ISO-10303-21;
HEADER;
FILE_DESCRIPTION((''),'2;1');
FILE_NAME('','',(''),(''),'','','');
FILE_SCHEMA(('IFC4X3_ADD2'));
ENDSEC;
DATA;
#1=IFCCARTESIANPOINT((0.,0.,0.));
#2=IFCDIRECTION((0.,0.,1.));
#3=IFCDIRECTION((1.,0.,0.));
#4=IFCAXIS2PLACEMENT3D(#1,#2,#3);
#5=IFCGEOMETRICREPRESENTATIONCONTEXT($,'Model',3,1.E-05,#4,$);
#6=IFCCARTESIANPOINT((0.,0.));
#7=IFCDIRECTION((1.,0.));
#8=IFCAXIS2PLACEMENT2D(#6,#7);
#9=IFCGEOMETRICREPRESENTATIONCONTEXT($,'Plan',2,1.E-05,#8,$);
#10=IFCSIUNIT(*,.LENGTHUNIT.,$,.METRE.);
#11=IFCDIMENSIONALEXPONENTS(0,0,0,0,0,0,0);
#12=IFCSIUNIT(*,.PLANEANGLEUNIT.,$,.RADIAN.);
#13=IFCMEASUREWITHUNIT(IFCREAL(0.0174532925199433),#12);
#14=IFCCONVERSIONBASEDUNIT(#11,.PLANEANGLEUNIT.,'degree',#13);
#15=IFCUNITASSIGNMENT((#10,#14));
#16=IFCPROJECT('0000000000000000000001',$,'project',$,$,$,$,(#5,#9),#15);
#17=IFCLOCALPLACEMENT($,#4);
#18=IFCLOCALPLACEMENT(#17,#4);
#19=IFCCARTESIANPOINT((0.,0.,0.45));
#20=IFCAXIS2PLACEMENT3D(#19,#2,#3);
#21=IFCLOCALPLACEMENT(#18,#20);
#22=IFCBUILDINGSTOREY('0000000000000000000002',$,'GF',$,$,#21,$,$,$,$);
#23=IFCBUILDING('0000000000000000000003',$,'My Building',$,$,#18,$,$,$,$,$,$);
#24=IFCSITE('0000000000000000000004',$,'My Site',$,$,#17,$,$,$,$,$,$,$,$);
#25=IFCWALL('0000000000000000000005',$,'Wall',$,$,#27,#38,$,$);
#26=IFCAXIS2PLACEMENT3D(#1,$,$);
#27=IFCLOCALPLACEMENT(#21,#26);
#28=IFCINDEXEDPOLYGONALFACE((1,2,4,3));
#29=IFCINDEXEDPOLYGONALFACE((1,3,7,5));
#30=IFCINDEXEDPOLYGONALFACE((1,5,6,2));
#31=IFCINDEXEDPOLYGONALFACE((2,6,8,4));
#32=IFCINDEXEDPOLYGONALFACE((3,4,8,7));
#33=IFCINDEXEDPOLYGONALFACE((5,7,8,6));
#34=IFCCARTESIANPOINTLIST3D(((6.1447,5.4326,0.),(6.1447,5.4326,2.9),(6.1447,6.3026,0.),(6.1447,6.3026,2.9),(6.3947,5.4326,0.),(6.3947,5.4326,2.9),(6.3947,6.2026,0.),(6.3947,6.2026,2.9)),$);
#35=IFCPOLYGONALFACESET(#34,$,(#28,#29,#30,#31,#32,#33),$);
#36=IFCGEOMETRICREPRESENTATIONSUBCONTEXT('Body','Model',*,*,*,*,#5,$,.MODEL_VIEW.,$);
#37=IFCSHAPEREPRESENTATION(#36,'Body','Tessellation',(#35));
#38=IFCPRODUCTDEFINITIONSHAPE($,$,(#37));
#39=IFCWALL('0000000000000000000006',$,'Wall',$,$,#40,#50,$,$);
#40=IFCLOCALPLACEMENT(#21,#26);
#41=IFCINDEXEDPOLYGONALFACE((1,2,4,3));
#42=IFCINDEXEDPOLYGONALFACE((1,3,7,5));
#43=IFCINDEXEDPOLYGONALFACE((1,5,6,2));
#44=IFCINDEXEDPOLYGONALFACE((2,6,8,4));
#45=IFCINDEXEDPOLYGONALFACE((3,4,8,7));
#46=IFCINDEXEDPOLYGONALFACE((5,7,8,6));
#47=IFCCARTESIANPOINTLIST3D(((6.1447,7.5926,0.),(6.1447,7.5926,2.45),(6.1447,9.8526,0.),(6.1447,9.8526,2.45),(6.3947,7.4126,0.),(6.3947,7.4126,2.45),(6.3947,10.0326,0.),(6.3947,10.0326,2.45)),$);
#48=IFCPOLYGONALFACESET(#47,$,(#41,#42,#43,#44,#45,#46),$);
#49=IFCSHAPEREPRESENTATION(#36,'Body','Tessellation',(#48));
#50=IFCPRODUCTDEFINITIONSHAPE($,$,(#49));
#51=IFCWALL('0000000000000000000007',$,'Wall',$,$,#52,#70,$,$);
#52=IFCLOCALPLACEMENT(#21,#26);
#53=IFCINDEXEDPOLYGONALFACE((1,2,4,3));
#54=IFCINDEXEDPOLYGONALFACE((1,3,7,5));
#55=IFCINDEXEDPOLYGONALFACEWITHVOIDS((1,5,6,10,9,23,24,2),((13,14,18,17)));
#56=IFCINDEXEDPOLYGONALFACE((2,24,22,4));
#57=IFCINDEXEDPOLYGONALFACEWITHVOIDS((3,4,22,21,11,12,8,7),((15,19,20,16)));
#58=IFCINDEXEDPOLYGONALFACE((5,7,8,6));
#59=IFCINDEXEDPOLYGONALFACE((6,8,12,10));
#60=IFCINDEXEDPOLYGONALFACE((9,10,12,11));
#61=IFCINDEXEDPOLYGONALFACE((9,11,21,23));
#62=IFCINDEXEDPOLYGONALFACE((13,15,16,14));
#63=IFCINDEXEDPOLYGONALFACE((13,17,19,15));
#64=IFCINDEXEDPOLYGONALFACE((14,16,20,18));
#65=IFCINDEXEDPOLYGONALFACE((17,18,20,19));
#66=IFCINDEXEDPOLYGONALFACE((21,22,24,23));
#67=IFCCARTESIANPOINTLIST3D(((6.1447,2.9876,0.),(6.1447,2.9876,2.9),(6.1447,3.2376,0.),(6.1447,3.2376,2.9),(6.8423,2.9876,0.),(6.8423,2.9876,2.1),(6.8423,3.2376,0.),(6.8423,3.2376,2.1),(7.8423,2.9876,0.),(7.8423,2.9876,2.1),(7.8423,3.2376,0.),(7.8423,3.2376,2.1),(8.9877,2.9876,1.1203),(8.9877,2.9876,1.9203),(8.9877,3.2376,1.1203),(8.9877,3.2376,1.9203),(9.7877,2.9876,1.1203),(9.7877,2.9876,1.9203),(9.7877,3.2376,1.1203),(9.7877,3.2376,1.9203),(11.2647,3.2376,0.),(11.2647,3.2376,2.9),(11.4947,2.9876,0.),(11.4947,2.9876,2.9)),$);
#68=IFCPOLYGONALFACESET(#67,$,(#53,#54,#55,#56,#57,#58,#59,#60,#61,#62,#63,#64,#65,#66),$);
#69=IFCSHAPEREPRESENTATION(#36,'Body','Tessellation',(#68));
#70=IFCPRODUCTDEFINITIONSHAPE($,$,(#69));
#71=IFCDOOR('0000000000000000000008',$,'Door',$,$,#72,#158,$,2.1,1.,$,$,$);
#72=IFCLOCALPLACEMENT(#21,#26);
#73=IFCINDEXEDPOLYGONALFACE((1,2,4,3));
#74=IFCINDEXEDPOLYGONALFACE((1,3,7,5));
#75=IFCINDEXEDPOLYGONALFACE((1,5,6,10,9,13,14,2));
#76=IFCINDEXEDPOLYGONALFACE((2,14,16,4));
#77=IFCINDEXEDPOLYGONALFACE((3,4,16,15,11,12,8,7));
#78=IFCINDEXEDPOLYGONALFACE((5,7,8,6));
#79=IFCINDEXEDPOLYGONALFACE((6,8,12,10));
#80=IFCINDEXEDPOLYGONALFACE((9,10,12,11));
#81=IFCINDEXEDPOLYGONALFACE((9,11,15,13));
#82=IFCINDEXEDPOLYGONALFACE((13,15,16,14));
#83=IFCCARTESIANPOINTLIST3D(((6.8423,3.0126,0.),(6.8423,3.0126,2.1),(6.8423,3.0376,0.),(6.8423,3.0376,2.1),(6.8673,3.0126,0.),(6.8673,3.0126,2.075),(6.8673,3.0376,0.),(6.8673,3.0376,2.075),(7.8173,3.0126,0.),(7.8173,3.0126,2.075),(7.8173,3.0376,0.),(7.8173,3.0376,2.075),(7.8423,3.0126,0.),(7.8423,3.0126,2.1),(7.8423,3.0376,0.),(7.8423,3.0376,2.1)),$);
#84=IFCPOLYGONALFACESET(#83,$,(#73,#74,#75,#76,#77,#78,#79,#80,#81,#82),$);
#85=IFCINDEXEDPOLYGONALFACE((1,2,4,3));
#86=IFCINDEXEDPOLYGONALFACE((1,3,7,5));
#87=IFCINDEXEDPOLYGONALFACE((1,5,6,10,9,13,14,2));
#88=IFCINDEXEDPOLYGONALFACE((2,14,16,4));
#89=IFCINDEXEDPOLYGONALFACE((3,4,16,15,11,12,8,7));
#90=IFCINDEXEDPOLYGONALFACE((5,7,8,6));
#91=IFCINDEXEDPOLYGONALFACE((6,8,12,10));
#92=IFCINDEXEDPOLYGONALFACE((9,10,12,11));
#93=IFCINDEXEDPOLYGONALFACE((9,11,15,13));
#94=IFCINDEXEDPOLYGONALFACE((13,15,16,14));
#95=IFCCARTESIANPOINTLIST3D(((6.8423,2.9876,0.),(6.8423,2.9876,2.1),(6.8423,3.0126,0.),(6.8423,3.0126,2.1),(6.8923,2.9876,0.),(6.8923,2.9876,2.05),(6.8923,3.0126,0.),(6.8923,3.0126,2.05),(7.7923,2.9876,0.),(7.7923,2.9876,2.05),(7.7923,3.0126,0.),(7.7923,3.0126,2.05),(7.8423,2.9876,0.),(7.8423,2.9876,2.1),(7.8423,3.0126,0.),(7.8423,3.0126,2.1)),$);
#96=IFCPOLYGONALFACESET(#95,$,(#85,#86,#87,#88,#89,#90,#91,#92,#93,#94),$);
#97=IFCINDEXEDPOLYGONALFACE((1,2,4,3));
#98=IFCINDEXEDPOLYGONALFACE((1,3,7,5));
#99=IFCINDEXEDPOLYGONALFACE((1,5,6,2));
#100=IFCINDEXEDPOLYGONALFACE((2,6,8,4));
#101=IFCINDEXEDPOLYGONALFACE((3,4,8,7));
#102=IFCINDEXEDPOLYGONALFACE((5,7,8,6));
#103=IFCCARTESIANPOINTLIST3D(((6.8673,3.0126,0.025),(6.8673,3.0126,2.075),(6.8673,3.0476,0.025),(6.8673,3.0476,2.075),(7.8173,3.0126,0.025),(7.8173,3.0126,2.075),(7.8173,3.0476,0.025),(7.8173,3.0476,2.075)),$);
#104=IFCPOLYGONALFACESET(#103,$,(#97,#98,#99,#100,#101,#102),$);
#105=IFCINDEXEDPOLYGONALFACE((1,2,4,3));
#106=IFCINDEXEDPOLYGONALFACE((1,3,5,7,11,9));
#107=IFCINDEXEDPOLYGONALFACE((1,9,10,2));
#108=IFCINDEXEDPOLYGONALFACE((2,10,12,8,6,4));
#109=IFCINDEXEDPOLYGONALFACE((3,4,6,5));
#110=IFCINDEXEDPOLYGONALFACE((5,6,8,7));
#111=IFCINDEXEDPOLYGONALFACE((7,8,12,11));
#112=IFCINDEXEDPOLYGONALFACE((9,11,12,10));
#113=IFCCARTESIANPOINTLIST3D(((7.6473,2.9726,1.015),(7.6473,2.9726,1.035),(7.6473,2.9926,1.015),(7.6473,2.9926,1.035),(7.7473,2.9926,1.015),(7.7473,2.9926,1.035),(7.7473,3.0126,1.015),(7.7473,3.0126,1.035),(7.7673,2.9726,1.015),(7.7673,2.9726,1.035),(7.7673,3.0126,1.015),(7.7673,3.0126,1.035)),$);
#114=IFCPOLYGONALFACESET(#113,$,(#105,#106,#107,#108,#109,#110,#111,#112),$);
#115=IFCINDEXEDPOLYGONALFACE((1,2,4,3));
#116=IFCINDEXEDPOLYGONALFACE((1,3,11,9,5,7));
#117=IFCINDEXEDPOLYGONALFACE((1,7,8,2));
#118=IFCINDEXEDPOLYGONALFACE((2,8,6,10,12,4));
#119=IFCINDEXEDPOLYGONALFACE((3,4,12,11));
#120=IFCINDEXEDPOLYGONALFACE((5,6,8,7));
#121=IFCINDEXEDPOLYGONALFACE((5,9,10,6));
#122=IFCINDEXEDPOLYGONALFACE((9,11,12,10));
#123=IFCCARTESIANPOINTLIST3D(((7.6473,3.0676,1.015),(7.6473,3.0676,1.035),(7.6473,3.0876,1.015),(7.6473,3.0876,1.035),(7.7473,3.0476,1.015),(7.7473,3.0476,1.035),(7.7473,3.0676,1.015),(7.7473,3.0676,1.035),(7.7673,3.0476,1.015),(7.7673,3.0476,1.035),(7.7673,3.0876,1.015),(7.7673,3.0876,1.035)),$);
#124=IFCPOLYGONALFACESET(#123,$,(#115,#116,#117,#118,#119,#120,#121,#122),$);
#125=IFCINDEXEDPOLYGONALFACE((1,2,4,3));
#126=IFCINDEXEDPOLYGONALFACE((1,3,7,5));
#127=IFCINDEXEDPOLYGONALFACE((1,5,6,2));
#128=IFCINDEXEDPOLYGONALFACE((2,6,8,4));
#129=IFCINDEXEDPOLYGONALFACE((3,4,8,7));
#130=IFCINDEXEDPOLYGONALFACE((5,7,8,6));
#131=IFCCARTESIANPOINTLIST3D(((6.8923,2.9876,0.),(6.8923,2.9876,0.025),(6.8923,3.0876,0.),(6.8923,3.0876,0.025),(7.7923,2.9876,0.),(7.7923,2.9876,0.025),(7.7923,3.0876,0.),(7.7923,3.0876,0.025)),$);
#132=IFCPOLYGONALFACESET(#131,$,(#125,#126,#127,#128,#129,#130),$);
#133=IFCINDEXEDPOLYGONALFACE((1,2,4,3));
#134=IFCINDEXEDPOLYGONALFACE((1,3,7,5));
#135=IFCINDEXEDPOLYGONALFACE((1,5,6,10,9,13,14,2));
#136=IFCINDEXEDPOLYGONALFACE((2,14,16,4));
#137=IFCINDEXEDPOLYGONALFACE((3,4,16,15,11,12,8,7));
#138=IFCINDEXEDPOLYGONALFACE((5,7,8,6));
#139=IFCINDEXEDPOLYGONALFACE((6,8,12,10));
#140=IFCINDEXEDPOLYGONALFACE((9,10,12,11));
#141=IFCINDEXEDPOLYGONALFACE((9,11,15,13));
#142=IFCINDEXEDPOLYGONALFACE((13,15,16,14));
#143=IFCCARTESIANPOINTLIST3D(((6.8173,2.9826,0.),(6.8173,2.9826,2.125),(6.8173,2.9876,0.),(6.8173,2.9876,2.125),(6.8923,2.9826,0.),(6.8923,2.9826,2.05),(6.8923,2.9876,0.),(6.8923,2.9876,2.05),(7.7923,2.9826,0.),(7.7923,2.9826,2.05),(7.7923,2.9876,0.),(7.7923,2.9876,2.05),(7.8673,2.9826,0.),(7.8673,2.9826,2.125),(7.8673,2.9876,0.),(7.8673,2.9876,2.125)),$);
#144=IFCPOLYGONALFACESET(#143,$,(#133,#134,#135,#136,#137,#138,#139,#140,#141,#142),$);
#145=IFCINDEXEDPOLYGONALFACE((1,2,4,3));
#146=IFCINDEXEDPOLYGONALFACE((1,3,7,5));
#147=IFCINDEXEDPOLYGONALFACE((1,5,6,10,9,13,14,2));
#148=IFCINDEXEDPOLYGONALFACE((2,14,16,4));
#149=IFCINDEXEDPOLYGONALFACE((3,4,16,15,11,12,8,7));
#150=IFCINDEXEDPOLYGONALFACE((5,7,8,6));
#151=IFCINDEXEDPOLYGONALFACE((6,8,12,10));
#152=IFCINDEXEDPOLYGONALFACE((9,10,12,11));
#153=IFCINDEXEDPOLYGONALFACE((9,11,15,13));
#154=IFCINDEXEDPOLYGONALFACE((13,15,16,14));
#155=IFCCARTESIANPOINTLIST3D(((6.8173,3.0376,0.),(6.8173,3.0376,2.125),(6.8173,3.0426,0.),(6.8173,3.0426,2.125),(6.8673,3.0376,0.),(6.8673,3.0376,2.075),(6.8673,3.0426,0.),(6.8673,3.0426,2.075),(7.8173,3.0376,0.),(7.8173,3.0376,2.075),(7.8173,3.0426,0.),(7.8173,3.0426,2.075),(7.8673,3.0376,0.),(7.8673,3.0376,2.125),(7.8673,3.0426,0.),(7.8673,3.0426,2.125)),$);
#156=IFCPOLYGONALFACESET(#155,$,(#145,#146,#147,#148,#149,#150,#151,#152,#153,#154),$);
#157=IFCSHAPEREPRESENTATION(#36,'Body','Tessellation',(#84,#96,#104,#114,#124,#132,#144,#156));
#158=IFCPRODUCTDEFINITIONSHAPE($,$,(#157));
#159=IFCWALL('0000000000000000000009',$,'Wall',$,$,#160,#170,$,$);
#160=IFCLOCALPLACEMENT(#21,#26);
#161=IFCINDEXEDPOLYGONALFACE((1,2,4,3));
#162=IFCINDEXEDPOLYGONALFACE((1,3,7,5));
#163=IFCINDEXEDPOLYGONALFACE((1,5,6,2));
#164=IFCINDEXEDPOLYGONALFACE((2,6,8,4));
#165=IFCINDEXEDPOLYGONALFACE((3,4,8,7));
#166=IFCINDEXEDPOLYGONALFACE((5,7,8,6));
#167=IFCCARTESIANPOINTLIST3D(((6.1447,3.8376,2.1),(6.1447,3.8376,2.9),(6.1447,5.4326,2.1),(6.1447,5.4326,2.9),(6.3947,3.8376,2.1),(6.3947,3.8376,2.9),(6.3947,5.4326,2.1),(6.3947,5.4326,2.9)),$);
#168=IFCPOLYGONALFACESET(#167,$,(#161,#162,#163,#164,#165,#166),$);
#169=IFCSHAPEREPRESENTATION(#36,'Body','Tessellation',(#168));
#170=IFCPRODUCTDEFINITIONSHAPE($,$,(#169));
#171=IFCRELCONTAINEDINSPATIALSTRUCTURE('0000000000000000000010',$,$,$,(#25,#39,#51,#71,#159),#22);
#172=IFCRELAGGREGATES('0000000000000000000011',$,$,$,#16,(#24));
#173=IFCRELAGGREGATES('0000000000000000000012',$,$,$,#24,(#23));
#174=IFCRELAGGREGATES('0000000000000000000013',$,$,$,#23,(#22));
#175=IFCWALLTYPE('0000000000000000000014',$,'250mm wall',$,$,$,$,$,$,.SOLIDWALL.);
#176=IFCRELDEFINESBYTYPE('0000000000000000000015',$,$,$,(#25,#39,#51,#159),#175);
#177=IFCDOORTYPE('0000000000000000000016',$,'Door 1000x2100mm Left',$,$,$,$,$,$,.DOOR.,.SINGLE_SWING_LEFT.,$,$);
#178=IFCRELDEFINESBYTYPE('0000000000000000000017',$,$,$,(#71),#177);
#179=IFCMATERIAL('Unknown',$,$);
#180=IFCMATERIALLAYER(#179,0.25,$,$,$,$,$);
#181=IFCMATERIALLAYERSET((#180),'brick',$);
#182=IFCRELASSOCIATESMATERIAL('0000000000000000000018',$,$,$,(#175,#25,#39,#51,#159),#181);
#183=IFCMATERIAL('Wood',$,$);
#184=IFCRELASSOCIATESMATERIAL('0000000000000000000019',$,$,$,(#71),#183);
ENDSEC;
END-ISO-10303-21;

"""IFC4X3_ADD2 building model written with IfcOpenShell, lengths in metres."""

from ifc_helpers import new_model, entity, si_unit, converted_unit, frame, origin_with_axes, origin_2d_with_axis, place, context, subcontext, project, spatial, line, indexed_curve, outline, extrude, shape, source, transform, mapped, material, layer, layer_set, layer_usage, type_object, type_shapes, element, fill, save


model = new_model("IFC4X3_ADD2")

# Units and contexts
model_context = context("Model", 3, precision=1e-05, world=origin_with_axes())
plan_context = context("Plan", 2, precision=1e-05, world=origin_2d_with_axis())
body_context_1 = subcontext(model_context, "Body", "Model", "MODEL_VIEW")
body_context_2 = subcontext(plan_context, "Body", "Plan", "PLAN_VIEW")
ifc_project = project(units=[si_unit("LENGTHUNIT", "METRE"), converted_unit("PLANEANGLEUNIT", "degree", entity("IfcReal", 0.0174532925199433), si_unit("PLANEANGLEUNIT", "RADIAN"), dimensions=[0, 0, 0, 0, 0, 0, 0])], contexts=[model_context, plan_context])

# Site, building, storey
site_placement = place(None, origin_with_axes())
site = spatial("IfcSite", under=ifc_project, at=site_placement, Name="My Site")
building_placement = place(site_placement, origin_with_axes())
building = spatial("IfcBuilding", under=site, at=building_placement, Name="My Building")
storey_placement = place(building_placement, frame((0.0, 0.0, 0.45), z_axis=(0.0, 0.0, 1.0), x_axis=(1.0, 0.0, 0.0)))
storey = spatial("IfcBuildingStorey", under=building, at=storey_placement, Name="GF")

# Shared definitions
ifc_material_1 = material(Name="Unknown")
ifc_layer_1 = layer(ifc_material_1, 0.25)
ifc_layer_set_1 = layer_set([ifc_layer_1], Name="brick")
wall_type_1 = type_object("IfcWallType", Name="250mm wall", PredefinedType="SOLIDWALL", material=ifc_layer_set_1)
shared_shape_1 = source(origin_with_axes(), body_context_1, "Body", "SweptSolid", [
    extrude(outline(indexed_curve([(0.0, 0.0), (0.8, 0.0), (0.8, 0.8), (0.0, 0.8)], segments=[line(1, 2, 3, 4, 1)])), frame((-0.4, -0.6, 0.0), z_axis=(0.0, -1.0, 0.0), x_axis=(1.0, 0.0, 0.0)), (0.0, 0.0, -1.0), 1.2),
])

# Walls
ifc_layer_usage_1 = layer_usage(ifc_layer_set_1, "AXIS2", "POSITIVE", 0.0)
wall_1_placement = place(storey_placement, frame((6.3947, 5.4326, 0.0), z_axis=(0.0, 0.0, 1.0), x_axis=(0.0, 1.0, 0.0)))
element("IfcWall", 1, at=wall_1_placement, inside=storey, type_object=wall_type_1, material=ifc_layer_usage_1, Name="Wall", context=body_context_1, shape_type="SweptSolid", body=[
    extrude(outline(indexed_curve([(0.0, 0.0), (0.0, 0.25), (0.87, 0.25), (0.77, 0.0)], segments=[line(1, 2, 3, 4, 1)])), origin_with_axes(), (0.0, 0.0, 1.0), 2.9),
])
ifc_layer_usage_2 = layer_usage(ifc_layer_set_1, "AXIS2", "POSITIVE", 0.0)
wall_2_placement = place(storey_placement, frame((6.3947, 7.5926, 0.0), z_axis=(0.0, 0.0, 1.0), x_axis=(0.0, 1.0, 0.0)))
element("IfcWall", 2, at=wall_2_placement, inside=storey, type_object=wall_type_1, material=ifc_layer_usage_2, Name="Wall", context=body_context_1, shape_type="SweptSolid", body=[
    extrude(outline(indexed_curve([(-0.18, 0.0), (0.0, 0.25), (2.26, 0.25), (2.44, 0.0)], segments=[line(1, 2, 3, 4, 1)])), origin_with_axes(), (0.0, 0.0, 1.0), 2.45),
])

# Wall, openings, door
ifc_layer_usage_3 = layer_usage(ifc_layer_set_1, "AXIS2", "POSITIVE", 0.0)
wall_3_placement = place(storey_placement, frame((6.1447, 2.9876, 0.0), z_axis=(0.0, 0.0, 1.0), x_axis=(1.0, 0.0, 0.0)))
wall_3 = element("IfcWall", 3, at=wall_3_placement, inside=storey, type_object=wall_type_1, material=ifc_layer_usage_3, Name="Wall", context=body_context_1, shape_type="SweptSolid", body=[
    extrude(outline(indexed_curve([(0.0, 0.0), (0.0, 0.25), (5.12, 0.25), (5.35, 0.0)], segments=[line(1, 2, 3, 4, 1)])), origin_with_axes(), (0.0, 0.0, 1.0), 2.9),
])
shared_shape_2 = source(origin_with_axes(), body_context_1, "Body", "SweptSolid", [
    extrude(outline(indexed_curve([(0.0, 0.0), (1.0, 0.0), (1.0, 2.1), (0.0, 2.1)], segments=[line(1, 2, 3, 4, 1)])), frame((0.0, -0.6, 0.0), z_axis=(0.0, -1.0, 0.0), x_axis=(1.0, 0.0, 0.0)), (0.0, 0.0, -1.0), 1.2),
])
opening_1_placement = place(wall_3_placement, frame((0.6976, 0.0, 0.0), z_axis=(0.0, 0.0, 1.0), x_axis=(1.0, 0.0, 0.0)))
opening_1 = element("IfcOpeningElement", 4, at=opening_1_placement, cuts=wall_3, PredefinedType="OPENING", context=body_context_1, shape_type="MappedRepresentation", body=[
    mapped(shared_shape_2, transform((0.0, 0.0, 0.0), x_axis=(1.0, 0.0, 0.0), y_axis=(0.0, 1.0, 0.0), z_axis=(0.0, 0.0, 1.0), scale=1.0)),
])
opening_2_placement = place(wall_3_placement, frame((3.2431, 0.0, 1.1203), z_axis=(0.0, 0.0, 1.0), x_axis=(1.0, 0.0, 0.0)))
element("IfcOpeningElement", 5, at=opening_2_placement, cuts=wall_3, PredefinedType="OPENING", context=body_context_1, shape_type="MappedRepresentation", body=[
    mapped(shared_shape_1, transform((0.0, 0.0, 0.0), x_axis=(1.0, 0.0, 0.0), y_axis=(0.0, 1.0, 0.0), z_axis=(0.0, 0.0, 1.0), scale=1.0)),
])
ifc_material_2 = material(Name="Wood")
door_type_1 = type_object("IfcDoorType", Name="Door 1000x2100mm Left", OperationType="SINGLE_SWING_LEFT", PredefinedType="DOOR")
shared_shape_3 = source(origin_with_axes(), body_context_1, "Body", "SweptSolid", [
    extrude(outline(indexed_curve([(0.0, 0.0), (0.0, 2.1), (1.0, 2.1), (1.0, 0.0), (0.975, 0.0), (0.975, 2.075), (0.025, 2.075), (0.025, 0.0)], segments=[line(1, 2, 3, 4, 5, 6, 7, 8, 1)])), frame((0.0, 0.025, 0.0), z_axis=(0.0, -1.0, 0.0), x_axis=(1.0, 0.0, 0.0)), (0.0, 0.0, -1.0), 0.025),
    extrude(outline(indexed_curve([(0.0, 0.0), (0.0, 2.1), (1.0, 2.1), (1.0, 0.0), (0.95, 0.0), (0.95, 2.05), (0.05, 2.05), (0.05, 0.0)], segments=[line(1, 2, 3, 4, 5, 6, 7, 8, 1)])), frame((0.0, 0.0, 0.0), z_axis=(0.0, -1.0, 0.0), x_axis=(1.0, 0.0, 0.0)), (0.0, 0.0, -1.0), 0.025),
    extrude(outline(indexed_curve([(0.0, 0.0), (0.95, 0.0), (0.95, 0.035), (0.0, 0.035)], segments=[line(1, 2, 3, 4, 1)])), frame((0.025, 0.025, 0.025), z_axis=(0.0, 0.0, 1.0), x_axis=(1.0, 0.0, 0.0)), (0.0, 0.0, 1.0), 2.05),
    extrude(outline(indexed_curve([(0.0, 0.0), (0.0, -0.04), (-0.12, -0.04), (-0.12, -0.02), (-0.02, -0.02), (-0.02, 0.0)], segments=[line(1, 2, 3, 4, 5, 6, 1)])), frame((0.925, 0.025, 1.015), z_axis=(0.0, 0.0, 1.0), x_axis=(1.0, 0.0, 0.0)), (0.0, 0.0, 1.0), 0.02),
    extrude(outline(indexed_curve([(0.0, 0.0), (0.0, 0.04), (-0.12, 0.04), (-0.12, 0.02), (-0.02, 0.02), (-0.02, 0.0)], segments=[line(1, 2, 3, 4, 5, 6, 1)])), frame((0.925, 0.06, 1.015), z_axis=(0.0, 0.0, 1.0), x_axis=(1.0, 0.0, 0.0)), (0.0, 0.0, 1.0), 0.02),
    extrude(outline(indexed_curve([(0.0, 0.0), (0.9, 0.0), (0.9, 0.1), (0.0, 0.1)], segments=[line(1, 2, 3, 4, 1)])), frame((0.05, 0.0, 0.0), z_axis=(0.0, 0.0, 1.0), x_axis=(1.0, 0.0, 0.0)), (0.0, 0.0, 1.0), 0.025),
    extrude(outline(indexed_curve([(0.0, 0.0), (0.0, 2.125), (1.05, 2.125), (1.05, 0.0), (0.975, 0.0), (0.975, 2.05), (0.075, 2.05), (0.075, 0.0)], segments=[line(1, 2, 3, 4, 5, 6, 7, 8, 1)])), frame((-0.025, -0.005, 0.0), z_axis=(0.0, -1.0, 0.0), x_axis=(1.0, 0.0, 0.0)), (0.0, 0.0, -1.0), 0.005),
    extrude(outline(indexed_curve([(0.0, 0.0), (0.0, 2.125), (1.05, 2.125), (1.05, 0.0), (1.0, 0.0), (1.0, 2.075), (0.05, 2.075), (0.05, 0.0)], segments=[line(1, 2, 3, 4, 5, 6, 7, 8, 1)])), frame((-0.025, 0.05, 0.0), z_axis=(0.0, -1.0, 0.0), x_axis=(1.0, 0.0, 0.0)), (0.0, 0.0, -1.0), 0.005),
])
shared_shape_4 = source(origin_with_axes(), body_context_2, "Body", "Curve2D", [
    entity("IfcIndexedPolyCurve", entity("IfcCartesianPointList2D", [[0.0, 0.0], [0.0, 0.05], [0.025, 0.05], [0.025, 0.025], [0.05, 0.025], [0.05, 0.0]]), [entity("IfcLineIndex", [1, 2, 3, 4, 5, 6, 1])]),
    entity("IfcIndexedPolyCurve", entity("IfcCartesianPointList2D", [[1.0, 0.0], [1.0, 0.05], [0.975, 0.05], [0.975, 0.025], [0.95, 0.025], [0.95, 0.0]]), [entity("IfcLineIndex", [1, 2, 3, 4, 5, 6, 1])]),
    entity("IfcTrimmedCurve", entity("IfcEllipse", entity("IfcAxis2Placement2D", entity("IfcCartesianPoint", [0.06, 0.05]), entity("IfcDirection", [1.0, 0.0])), 0.915, 0.95), [entity("IfcCartesianPoint", [0.975, 0.05])], [entity("IfcCartesianPoint", [0.06, 1.0])], True, "CARTESIAN"),
    entity("IfcIndexedPolyCurve", entity("IfcCartesianPointList2D", [[0.025, 0.05], [0.06, 0.05], [0.06, 1.0], [0.025, 1.0]]), [entity("IfcLineIndex", [1, 2, 3, 4, 1])]),
])
type_shapes(door_type_1, [shared_shape_3, shared_shape_4])
door_1_placement = place(opening_1_placement, origin_with_axes())
door_1 = element("IfcDoor", 6, at=door_1_placement, inside=storey, type_object=door_type_1, material=ifc_material_2, Name="Door", OverallHeight=2.1, OverallWidth=1.0, shapes=[
    shape(body_context_1, "Body", "MappedRepresentation", [mapped(shared_shape_3, transform((0.0, 0.0, 0.0), x_axis=(1.0, 0.0, 0.0), y_axis=(0.0, 1.0, 0.0), z_axis=(0.0, 0.0, 1.0), scale=1.0))]),
    shape(body_context_2, "Body", "MappedRepresentation", [mapped(shared_shape_4, transform((0.0, 0.0, 0.0), x_axis=(1.0, 0.0, 0.0), y_axis=(0.0, 1.0, 0.0), z_axis=(0.0, 0.0, 1.0), scale=1.0))]),
])
fill(opening_1, door_1)

# Wall
ifc_layer_usage_4 = layer_usage(ifc_layer_set_1, "AXIS2", "POSITIVE", 0.0)
wall_4_placement = place(storey_placement, frame((6.3947, 3.8376, 2.1), z_axis=(0.0, 0.0, 1.0), x_axis=(0.0, 1.0, 0.0)))
element("IfcWall", 7, at=wall_4_placement, inside=storey, type_object=wall_type_1, material=ifc_layer_usage_4, Name="Wall", context=body_context_1, shape_type="SweptSolid", body=[
    extrude(outline(indexed_curve([(0.0, 0.0), (0.0, 0.25), (1.595, 0.25), (1.595, 0.0)], segments=[line(1, 2, 3, 4, 1)])), origin_with_axes(), (0.0, 0.0, 1.0), 0.8),
])

save(model, "model.ifc")
